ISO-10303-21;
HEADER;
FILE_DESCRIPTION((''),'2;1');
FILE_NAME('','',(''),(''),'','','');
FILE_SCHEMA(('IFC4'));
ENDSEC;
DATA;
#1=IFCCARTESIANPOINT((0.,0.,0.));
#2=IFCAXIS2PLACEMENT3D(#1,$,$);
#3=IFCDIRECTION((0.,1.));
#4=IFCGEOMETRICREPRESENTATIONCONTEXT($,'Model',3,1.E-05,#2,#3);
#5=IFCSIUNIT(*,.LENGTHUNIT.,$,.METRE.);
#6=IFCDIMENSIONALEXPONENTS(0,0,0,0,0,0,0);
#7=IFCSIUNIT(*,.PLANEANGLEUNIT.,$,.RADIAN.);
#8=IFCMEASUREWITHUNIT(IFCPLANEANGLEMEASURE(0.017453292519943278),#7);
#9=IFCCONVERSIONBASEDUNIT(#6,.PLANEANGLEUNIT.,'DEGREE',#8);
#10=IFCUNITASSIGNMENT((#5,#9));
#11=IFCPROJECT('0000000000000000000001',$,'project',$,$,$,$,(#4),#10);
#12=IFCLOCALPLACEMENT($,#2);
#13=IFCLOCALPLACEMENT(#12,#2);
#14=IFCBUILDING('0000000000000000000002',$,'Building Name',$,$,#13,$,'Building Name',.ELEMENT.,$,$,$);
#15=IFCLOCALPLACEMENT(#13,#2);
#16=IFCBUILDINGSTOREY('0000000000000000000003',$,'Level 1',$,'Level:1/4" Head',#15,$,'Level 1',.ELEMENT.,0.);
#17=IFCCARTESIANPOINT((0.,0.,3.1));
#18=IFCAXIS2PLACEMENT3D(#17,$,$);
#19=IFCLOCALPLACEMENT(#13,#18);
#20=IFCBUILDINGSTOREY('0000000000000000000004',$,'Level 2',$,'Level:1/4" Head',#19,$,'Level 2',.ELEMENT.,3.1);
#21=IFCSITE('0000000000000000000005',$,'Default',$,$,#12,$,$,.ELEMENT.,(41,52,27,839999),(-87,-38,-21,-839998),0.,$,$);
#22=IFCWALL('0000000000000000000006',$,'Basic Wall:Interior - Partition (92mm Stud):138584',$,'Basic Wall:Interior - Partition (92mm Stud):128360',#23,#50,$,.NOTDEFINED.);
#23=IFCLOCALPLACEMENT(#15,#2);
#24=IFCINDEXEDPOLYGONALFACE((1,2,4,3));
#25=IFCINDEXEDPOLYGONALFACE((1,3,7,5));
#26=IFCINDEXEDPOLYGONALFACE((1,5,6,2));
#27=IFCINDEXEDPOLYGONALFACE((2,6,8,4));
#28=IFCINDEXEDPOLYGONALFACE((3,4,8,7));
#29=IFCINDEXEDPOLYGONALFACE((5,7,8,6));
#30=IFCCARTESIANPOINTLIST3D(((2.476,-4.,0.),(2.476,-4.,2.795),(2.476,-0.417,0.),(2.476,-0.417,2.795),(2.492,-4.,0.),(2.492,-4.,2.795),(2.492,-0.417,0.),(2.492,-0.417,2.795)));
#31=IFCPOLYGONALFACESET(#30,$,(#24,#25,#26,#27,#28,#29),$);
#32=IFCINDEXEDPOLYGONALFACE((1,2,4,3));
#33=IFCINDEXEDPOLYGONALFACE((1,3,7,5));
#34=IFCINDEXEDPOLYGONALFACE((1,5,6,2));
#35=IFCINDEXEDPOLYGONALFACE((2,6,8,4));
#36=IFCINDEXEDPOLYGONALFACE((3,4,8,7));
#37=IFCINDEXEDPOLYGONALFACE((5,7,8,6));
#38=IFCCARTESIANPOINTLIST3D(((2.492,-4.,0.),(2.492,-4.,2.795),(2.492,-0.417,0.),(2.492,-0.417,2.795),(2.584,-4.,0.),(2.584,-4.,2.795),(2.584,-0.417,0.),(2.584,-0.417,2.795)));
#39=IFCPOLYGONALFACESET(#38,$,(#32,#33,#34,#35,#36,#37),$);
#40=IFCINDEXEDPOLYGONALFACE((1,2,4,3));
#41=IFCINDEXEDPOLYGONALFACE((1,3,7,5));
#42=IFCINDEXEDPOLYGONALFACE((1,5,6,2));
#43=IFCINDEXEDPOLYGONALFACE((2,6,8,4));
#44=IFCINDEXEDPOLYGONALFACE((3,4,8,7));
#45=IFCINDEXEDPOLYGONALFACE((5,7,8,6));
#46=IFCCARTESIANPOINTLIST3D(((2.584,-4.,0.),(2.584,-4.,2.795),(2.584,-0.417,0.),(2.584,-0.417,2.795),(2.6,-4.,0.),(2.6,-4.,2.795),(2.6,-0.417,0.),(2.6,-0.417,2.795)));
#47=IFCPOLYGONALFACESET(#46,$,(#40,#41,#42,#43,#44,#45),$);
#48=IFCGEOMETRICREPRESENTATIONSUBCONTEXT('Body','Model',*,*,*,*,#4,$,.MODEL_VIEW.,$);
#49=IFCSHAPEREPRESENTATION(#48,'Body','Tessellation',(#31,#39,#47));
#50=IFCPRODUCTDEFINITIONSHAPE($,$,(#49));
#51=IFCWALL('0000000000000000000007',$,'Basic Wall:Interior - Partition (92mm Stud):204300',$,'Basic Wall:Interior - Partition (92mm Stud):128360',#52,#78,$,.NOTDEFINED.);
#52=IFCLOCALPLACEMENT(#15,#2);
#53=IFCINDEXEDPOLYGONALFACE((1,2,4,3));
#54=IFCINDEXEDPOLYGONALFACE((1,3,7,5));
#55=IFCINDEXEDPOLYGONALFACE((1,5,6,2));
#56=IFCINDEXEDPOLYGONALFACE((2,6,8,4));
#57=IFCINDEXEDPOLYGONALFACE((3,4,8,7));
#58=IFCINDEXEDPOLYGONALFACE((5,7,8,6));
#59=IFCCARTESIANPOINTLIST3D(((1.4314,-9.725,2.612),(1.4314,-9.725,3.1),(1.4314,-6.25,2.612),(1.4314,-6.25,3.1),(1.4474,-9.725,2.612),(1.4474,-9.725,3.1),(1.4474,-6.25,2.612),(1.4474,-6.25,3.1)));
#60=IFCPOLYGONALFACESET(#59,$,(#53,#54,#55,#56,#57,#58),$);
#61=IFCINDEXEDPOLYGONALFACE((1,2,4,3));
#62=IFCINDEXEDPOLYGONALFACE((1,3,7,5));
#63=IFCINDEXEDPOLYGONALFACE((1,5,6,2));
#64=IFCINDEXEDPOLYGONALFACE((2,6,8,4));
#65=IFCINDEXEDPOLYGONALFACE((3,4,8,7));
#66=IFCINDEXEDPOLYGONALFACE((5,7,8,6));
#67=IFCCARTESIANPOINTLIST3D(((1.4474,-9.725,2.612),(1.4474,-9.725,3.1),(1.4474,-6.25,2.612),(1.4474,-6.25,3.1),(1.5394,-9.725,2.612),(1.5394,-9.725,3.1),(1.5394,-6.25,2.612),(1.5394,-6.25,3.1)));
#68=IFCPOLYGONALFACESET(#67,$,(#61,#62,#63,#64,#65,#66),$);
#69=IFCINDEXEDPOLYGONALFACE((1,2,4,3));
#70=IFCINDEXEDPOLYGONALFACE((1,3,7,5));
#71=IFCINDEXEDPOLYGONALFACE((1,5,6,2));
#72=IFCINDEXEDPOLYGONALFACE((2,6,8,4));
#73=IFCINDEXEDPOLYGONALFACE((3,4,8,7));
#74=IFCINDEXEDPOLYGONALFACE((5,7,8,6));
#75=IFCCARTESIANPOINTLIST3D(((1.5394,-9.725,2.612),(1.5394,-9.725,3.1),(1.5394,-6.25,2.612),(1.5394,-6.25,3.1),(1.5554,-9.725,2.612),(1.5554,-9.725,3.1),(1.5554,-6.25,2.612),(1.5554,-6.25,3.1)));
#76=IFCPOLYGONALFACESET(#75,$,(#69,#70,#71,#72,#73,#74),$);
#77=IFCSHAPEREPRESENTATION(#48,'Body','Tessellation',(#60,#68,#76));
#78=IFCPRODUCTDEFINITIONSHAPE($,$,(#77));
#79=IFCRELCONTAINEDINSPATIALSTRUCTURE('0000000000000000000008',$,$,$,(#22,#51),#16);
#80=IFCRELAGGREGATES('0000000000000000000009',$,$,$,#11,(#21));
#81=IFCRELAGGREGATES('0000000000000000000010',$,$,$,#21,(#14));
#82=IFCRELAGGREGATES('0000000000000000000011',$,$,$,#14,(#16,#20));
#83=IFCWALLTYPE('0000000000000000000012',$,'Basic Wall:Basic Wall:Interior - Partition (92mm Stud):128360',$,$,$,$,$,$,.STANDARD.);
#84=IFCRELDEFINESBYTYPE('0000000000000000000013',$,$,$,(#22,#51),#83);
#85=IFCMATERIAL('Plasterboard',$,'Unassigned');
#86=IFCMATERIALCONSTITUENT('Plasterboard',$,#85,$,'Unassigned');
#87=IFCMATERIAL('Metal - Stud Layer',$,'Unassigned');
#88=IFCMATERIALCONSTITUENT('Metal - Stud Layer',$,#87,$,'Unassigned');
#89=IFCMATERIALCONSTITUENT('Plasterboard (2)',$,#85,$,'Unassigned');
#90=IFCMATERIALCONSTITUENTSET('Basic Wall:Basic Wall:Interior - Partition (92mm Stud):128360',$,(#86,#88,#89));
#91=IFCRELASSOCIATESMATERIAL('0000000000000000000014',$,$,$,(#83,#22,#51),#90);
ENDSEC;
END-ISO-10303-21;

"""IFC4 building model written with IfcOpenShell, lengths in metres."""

from ifc_helpers import new_model, entity, si_unit, converted_unit, direction, frame, origin, place, context, subcontext, project, spatial, indexed_curve, outline, extrude, material, constituent, constituent_set, type_object, element, save


model = new_model("IFC4")

# Units and contexts
model_context = context("Model", 3, precision=1e-05, world=origin(), true_north=direction((0.0, 1.0)))
body_context = subcontext(model_context, "Body", "Model", "MODEL_VIEW")
ifc_project = project(units=[si_unit("LENGTHUNIT", "METRE"), converted_unit("PLANEANGLEUNIT", "DEGREE", entity("IfcPlaneAngleMeasure", 0.017453292519943278), si_unit("PLANEANGLEUNIT", "RADIAN"), dimensions=[0, 0, 0, 0, 0, 0, 0])], contexts=[model_context])

# Site, building, storey
site_placement = place(None, origin())
site = spatial("IfcSite", under=ifc_project, at=site_placement, Name="Default", CompositionType="ELEMENT", RefLatitude=(41, 52, 27, 839999), RefLongitude=(-87, -38, -21, -839998), RefElevation=0.0)
building_placement = place(site_placement, origin())
building = spatial("IfcBuilding", under=site, at=building_placement, Name="Building Name", LongName="Building Name", CompositionType="ELEMENT")
storey_1_placement = place(building_placement, origin())
storey_1 = spatial("IfcBuildingStorey", under=building, at=storey_1_placement, Name="Level 1", ObjectType="Level:1/4\" Head", LongName="Level 1", CompositionType="ELEMENT", Elevation=0.0)

# Shared definitions
ifc_material_1 = material(Name="Plasterboard", Category="Unassigned")
ifc_material_2 = material(Name="Metal - Stud Layer", Category="Unassigned")
ifc_constituent_1 = constituent(ifc_material_1, Name="Plasterboard", Category="Unassigned")
ifc_constituent_2 = constituent(ifc_material_2, Name="Metal - Stud Layer", Category="Unassigned")
ifc_constituent_3 = constituent(ifc_material_1, Name="Plasterboard (2)", Category="Unassigned")
ifc_constituent_set_1 = constituent_set(constituents=[ifc_constituent_1, ifc_constituent_2, ifc_constituent_3], Name="Basic Wall:Basic Wall:Interior - Partition (92mm Stud):128360")
wall_type_1 = type_object("IfcWallType", Name="Basic Wall:Basic Wall:Interior - Partition (92mm Stud):128360", PredefinedType="STANDARD", material=ifc_constituent_set_1)

# Shared definitions
storey_2_placement = place(building_placement, frame((0.0, 0.0, 3.1)))
storey_2 = spatial("IfcBuildingStorey", under=building, at=storey_2_placement, Name="Level 2", ObjectType="Level:1/4\" Head", LongName="Level 2", CompositionType="ELEMENT", Elevation=3.1)

# Walls
wall_1_placement = place(storey_1_placement, frame((2.538, -0.417, 0.0), z_axis=(0.0, 0.0, 1.0), x_axis=(0.0, -1.0, 0.0)))
element("IfcWall", 1, at=wall_1_placement, inside=storey_1, type_object=wall_type_1, material=ifc_constituent_set_1, Name="Basic Wall:Interior - Partition (92mm Stud):138584", ObjectType="Basic Wall:Interior - Partition (92mm Stud):128360", PredefinedType="NOTDEFINED", context=body_context, shape_type="SweptSolid", body=[
    extrude(outline(indexed_curve([(-0.008, -1.7915), (0.008, -1.7915), (0.008, 1.7915), (-0.008, 1.7915), (-0.008, -1.7915)], self_intersect=False)), frame((1.7915, -0.054, 0.0), z_axis=(0.0, 0.0, 1.0), x_axis=(0.0, 1.0, 0.0)), (0.0, 0.0, 1.0), 2.795),
    extrude(outline(indexed_curve([(-1.7915, -0.046), (1.7915, -0.046), (1.7915, 0.046), (-1.7915, 0.046), (-1.7915, -0.046)], self_intersect=False)), frame((1.7915, 0.0, 0.0)), (0.0, 0.0, 1.0), 2.795),
    extrude(outline(indexed_curve([(-0.008, -1.7915), (0.008, -1.7915), (0.008, 1.7915), (-0.008, 1.7915), (-0.008, -1.7915)], self_intersect=False)), frame((1.7915, 0.054, 0.0), z_axis=(0.0, 0.0, 1.0), x_axis=(0.0, -1.0, 0.0)), (0.0, 0.0, 1.0), 2.795),
])
wall_2_placement = place(storey_1_placement, frame((1.4934, -6.25, 2.612), z_axis=(0.0, 0.0, 1.0), x_axis=(0.0, -1.0, 0.0)))
element("IfcWall", 2, at=wall_2_placement, inside=storey_1, type_object=wall_type_1, material=ifc_constituent_set_1, Name="Basic Wall:Interior - Partition (92mm Stud):204300", ObjectType="Basic Wall:Interior - Partition (92mm Stud):128360", PredefinedType="NOTDEFINED", context=body_context, shape_type="SweptSolid", body=[
    extrude(outline(indexed_curve([(-0.008, -1.7375), (0.008, -1.7375), (0.008, 1.7375), (-0.008, 1.7375), (-0.008, -1.7375)], self_intersect=False)), frame((1.7375, -0.054, 0.0), z_axis=(0.0, 0.0, 1.0), x_axis=(0.0, 1.0, 0.0)), (0.0, 0.0, 1.0), 0.488),
    extrude(outline(indexed_curve([(-0.046, -1.7375), (0.046, -1.7375), (0.046, 1.7375), (-0.046, 1.7375), (-0.046, -1.7375)], self_intersect=False)), frame((1.7375, 0.0, 0.0), z_axis=(0.0, 0.0, 1.0), x_axis=(0.0, 1.0, 0.0)), (0.0, 0.0, 1.0), 0.488),
    extrude(outline(indexed_curve([(-0.008, -1.7375), (0.008, -1.7375), (0.008, 1.7375), (-0.008, 1.7375), (-0.008, -1.7375)], self_intersect=False)), frame((1.7375, 0.054, 0.0), z_axis=(0.0, 0.0, 1.0), x_axis=(0.0, 1.0, 0.0)), (0.0, 0.0, 1.0), 0.488),
])

save(model, "model.ifc")
